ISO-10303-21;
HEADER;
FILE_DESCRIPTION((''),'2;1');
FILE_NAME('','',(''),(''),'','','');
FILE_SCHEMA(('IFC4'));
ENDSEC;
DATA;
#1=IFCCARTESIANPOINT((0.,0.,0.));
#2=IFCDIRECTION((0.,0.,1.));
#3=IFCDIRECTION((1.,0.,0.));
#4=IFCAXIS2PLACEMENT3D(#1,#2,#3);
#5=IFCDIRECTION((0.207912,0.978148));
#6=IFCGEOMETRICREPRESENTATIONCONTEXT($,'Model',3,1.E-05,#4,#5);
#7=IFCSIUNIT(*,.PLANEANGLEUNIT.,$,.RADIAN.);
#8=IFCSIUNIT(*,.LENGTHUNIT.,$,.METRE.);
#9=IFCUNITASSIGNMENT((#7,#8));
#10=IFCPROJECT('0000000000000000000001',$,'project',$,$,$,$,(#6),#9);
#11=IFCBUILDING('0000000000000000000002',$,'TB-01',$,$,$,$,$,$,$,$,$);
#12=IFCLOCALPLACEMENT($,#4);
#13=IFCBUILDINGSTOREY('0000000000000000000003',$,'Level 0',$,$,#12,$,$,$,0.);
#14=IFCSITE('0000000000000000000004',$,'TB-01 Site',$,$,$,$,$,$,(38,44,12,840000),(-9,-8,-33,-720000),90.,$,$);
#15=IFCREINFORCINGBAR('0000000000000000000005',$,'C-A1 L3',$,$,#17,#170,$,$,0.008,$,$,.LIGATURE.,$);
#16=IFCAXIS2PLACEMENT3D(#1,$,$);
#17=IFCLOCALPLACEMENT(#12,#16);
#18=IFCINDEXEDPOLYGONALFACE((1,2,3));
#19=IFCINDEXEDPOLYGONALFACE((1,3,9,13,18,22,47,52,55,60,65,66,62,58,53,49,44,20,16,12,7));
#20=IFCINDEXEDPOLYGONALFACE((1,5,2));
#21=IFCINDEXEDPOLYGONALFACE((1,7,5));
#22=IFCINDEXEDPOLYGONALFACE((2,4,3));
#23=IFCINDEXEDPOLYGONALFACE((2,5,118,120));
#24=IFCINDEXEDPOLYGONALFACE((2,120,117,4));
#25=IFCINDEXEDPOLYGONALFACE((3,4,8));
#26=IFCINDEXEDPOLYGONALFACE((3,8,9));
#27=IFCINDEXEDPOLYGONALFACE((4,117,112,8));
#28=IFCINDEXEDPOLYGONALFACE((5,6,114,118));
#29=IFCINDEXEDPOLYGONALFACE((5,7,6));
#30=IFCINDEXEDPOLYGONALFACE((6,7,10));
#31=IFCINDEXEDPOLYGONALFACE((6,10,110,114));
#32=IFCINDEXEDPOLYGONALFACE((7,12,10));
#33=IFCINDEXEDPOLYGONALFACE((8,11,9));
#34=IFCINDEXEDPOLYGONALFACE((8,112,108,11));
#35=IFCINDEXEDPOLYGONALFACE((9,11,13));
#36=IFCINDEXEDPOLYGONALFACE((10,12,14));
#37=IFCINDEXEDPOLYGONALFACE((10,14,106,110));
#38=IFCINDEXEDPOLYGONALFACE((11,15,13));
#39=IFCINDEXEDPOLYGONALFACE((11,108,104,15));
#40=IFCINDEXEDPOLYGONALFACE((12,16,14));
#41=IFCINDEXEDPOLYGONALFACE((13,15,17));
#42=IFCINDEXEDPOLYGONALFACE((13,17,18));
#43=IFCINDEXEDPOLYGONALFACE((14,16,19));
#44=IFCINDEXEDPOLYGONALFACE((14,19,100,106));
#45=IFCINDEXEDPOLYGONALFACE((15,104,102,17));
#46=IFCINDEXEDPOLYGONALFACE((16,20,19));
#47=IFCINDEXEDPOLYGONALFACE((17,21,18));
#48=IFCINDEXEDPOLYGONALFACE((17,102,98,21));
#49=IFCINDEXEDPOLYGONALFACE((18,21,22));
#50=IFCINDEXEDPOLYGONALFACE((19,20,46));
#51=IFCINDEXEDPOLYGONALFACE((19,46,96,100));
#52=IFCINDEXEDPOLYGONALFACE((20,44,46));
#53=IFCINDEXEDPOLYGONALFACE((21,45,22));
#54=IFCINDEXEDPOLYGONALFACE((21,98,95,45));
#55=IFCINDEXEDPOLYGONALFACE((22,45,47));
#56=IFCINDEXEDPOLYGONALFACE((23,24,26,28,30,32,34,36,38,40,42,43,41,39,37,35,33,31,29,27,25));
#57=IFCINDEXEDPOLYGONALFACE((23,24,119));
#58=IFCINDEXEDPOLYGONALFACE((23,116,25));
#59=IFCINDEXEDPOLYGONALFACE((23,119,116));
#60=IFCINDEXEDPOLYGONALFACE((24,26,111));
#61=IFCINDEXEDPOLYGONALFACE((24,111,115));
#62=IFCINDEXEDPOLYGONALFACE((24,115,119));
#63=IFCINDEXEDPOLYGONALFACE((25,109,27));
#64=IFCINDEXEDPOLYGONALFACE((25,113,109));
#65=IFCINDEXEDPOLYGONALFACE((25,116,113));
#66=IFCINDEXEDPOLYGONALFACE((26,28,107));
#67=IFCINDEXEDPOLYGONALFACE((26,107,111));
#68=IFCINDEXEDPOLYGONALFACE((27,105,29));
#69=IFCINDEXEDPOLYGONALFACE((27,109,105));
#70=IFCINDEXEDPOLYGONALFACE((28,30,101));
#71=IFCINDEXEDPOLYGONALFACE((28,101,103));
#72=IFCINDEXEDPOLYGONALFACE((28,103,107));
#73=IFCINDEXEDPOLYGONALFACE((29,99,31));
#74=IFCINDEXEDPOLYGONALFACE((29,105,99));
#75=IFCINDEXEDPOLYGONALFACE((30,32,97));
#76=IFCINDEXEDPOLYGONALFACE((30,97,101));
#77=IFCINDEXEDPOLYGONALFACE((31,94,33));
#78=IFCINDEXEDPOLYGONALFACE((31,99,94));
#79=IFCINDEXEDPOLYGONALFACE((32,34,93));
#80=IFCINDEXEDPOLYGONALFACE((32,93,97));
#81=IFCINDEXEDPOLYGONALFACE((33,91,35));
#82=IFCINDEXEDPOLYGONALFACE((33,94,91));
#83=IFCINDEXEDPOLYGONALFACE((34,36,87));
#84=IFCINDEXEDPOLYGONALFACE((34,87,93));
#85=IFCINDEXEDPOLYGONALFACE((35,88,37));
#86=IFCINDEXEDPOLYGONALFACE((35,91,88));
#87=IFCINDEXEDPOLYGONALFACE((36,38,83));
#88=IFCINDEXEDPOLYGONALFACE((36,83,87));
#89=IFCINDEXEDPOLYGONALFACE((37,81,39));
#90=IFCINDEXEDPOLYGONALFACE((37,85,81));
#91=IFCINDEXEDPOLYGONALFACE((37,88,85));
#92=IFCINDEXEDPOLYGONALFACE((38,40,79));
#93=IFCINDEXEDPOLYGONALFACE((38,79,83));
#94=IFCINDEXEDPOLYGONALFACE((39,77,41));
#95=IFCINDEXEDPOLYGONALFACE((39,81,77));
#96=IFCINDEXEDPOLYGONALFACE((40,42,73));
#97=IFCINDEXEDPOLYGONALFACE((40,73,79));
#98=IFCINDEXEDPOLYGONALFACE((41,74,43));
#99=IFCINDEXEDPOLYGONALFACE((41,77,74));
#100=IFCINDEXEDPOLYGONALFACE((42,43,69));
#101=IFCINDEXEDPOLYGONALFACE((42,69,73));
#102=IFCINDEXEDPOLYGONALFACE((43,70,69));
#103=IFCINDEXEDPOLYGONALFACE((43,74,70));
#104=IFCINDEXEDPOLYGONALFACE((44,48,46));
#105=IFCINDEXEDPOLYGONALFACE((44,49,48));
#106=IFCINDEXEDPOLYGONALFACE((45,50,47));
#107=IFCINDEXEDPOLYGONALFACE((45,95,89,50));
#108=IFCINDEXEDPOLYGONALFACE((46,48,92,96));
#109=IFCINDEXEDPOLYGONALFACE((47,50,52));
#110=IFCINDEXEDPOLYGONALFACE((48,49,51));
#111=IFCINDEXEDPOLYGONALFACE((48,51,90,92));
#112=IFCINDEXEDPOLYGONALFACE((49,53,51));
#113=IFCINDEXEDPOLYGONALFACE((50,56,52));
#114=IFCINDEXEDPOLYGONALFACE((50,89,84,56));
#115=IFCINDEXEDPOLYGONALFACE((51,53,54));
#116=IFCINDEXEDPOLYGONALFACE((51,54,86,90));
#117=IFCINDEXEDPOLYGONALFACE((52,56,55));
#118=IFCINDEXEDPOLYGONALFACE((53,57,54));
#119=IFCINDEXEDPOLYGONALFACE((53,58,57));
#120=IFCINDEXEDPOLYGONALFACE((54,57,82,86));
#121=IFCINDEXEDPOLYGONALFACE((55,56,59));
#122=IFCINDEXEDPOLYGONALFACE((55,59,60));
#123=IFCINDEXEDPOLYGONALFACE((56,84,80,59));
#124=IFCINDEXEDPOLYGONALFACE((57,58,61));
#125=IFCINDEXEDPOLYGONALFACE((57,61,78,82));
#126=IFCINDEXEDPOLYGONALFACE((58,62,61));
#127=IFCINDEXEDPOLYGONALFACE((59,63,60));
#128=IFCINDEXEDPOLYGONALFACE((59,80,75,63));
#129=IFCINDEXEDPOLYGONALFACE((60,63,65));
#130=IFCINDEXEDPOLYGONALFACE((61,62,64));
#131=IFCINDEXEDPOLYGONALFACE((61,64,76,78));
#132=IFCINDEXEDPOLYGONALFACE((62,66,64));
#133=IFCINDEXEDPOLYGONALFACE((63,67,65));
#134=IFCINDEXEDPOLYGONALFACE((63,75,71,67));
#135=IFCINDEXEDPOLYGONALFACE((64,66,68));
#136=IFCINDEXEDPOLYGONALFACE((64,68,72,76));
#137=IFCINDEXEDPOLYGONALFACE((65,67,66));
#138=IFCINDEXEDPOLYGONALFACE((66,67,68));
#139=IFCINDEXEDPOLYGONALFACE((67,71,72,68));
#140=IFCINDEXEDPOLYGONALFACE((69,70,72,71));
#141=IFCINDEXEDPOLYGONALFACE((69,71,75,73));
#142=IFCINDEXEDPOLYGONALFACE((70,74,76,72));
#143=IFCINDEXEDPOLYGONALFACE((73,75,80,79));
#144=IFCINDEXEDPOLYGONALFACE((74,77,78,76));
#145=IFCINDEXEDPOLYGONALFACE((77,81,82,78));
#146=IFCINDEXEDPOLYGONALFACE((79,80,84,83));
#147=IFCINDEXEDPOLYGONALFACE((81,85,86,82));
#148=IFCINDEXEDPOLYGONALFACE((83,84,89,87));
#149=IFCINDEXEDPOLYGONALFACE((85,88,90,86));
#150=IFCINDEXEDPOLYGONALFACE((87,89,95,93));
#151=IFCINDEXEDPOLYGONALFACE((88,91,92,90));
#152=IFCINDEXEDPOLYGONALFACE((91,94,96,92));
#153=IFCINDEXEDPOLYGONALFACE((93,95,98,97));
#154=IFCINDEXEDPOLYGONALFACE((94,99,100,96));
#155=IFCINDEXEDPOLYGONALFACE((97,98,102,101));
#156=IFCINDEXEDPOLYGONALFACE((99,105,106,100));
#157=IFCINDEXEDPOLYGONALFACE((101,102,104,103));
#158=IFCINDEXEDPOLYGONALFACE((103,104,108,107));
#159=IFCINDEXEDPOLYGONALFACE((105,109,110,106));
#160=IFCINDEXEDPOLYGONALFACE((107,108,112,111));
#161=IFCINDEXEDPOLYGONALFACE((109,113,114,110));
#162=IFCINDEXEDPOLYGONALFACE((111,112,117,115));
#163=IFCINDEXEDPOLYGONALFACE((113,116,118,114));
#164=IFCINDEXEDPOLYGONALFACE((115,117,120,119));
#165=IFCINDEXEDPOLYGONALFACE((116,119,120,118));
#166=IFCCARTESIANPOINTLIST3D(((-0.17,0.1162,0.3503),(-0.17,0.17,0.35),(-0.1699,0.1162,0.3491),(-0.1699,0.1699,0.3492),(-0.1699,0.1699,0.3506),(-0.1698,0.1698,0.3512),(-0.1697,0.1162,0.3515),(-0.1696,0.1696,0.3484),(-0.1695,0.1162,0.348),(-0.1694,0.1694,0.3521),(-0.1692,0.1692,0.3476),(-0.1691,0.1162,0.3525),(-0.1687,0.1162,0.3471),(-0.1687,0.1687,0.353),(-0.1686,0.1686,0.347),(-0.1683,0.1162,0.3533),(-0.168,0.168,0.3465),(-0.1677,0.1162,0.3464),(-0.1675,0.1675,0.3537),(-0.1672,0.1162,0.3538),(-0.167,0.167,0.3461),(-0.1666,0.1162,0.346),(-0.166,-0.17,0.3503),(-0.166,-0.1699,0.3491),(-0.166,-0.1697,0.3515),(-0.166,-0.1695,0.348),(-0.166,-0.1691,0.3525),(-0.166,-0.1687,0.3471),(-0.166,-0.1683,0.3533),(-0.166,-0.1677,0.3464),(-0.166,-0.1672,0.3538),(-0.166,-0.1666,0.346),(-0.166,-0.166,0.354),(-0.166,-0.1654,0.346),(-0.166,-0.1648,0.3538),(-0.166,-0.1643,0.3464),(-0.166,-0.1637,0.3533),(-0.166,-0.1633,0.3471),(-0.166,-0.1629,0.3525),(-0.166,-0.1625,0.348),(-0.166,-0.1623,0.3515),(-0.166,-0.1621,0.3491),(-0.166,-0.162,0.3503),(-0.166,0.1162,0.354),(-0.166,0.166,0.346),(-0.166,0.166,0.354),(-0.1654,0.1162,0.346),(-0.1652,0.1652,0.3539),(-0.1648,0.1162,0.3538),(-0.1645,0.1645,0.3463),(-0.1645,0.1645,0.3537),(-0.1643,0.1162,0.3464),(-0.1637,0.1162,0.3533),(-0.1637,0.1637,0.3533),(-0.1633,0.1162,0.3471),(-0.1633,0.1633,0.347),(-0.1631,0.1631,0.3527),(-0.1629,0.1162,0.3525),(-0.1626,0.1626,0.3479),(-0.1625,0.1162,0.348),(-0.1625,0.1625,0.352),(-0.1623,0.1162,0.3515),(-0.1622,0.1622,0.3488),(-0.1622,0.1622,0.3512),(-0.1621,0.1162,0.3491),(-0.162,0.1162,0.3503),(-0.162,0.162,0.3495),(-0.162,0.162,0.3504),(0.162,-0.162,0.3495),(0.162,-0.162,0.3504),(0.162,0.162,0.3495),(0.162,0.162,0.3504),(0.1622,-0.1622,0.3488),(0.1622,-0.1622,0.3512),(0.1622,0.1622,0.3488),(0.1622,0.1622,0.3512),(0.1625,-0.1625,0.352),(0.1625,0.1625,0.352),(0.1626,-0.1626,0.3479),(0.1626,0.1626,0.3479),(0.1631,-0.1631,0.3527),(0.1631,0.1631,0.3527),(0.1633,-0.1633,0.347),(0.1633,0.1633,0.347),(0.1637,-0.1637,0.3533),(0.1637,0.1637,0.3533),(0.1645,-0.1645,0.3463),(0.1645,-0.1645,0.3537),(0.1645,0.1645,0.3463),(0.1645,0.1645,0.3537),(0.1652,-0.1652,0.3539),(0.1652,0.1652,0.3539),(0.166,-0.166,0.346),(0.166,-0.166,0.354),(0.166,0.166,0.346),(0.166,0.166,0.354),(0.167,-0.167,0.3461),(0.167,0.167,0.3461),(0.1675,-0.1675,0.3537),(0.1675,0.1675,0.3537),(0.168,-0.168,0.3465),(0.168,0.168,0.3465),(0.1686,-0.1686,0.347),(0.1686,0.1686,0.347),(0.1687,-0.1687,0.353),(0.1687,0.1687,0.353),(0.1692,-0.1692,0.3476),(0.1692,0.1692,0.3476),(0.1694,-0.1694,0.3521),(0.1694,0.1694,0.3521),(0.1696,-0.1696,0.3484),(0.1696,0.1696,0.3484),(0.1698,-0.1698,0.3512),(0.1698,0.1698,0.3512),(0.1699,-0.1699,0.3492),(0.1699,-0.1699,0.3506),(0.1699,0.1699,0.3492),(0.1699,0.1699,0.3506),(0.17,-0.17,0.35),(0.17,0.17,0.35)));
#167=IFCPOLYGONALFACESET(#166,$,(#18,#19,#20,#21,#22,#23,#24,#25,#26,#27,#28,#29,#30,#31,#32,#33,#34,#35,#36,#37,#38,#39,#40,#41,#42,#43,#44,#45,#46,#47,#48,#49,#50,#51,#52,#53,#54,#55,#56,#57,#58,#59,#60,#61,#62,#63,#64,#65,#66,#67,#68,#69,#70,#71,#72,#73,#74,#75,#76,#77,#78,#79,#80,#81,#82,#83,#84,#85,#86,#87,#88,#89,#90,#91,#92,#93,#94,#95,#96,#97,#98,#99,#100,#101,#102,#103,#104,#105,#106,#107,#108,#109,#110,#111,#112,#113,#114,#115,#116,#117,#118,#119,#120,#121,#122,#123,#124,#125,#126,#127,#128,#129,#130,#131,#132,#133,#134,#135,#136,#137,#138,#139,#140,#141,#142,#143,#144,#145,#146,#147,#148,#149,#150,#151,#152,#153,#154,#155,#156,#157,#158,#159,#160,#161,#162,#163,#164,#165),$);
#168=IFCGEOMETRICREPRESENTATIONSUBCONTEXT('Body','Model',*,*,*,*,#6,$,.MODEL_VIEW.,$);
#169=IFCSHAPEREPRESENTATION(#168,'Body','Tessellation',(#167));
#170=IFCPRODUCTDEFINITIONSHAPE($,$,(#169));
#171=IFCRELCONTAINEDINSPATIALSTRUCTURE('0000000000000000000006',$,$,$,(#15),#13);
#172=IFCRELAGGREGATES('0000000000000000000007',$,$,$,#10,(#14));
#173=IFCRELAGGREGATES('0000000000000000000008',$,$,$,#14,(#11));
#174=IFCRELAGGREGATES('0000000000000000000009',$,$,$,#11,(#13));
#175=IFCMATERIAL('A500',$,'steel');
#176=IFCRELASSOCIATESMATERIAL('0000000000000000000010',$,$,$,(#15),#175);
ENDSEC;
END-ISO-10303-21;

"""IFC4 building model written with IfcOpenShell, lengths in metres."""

from ifc_helpers import new_model, entity, si_unit, direction, origin_with_axes, place, context, subcontext, project, spatial, material, element, save


model = new_model("IFC4")

# Units and contexts
model_context = context("Model", 3, precision=1e-05, world=origin_with_axes(), true_north=direction((0.207912, 0.978148)))
body_context = subcontext(model_context, "Body", "Model", "MODEL_VIEW")
ifc_project = project(units=[si_unit("PLANEANGLEUNIT", "RADIAN"), si_unit("LENGTHUNIT", "METRE")], contexts=[model_context])

# Site, building, storey
site = spatial("IfcSite", under=ifc_project, Name="TB-01 Site", RefLatitude=(38, 44, 12, 840000), RefLongitude=(-9, -8, -33, -720000), RefElevation=90.0)
building = spatial("IfcBuilding", under=site, Name="TB-01")
storey_placement = place(None, origin_with_axes())
storey = spatial("IfcBuildingStorey", under=building, at=storey_placement, Name="Level 0", Elevation=0.0)

# Reinforcing bar
ifc_material_1 = material(Name="A500", Category="steel")
reinforcing_bar_1_placement = place(storey_placement, origin_with_axes())
element("IfcReinforcingBar", 1, at=reinforcing_bar_1_placement, inside=storey, material=ifc_material_1, Name="C-A1 L3", NominalDiameter=0.008, PredefinedType="LIGATURE", context=body_context, shape_type="AdvancedSweptSolid", body=[
    entity("IfcSweptDiskSolid", entity("IfcPolyline", [entity("IfcCartesianPoint", [-0.166, -0.166, 0.35]), entity("IfcCartesianPoint", [0.166, -0.166, 0.35]), entity("IfcCartesianPoint", [0.166, 0.166, 0.35]), entity("IfcCartesianPoint", [-0.166, 0.166, 0.35]), entity("IfcCartesianPoint", [-0.166, 0.1162, 0.35])]), 0.004),
])

save(model, "model.ifc")
